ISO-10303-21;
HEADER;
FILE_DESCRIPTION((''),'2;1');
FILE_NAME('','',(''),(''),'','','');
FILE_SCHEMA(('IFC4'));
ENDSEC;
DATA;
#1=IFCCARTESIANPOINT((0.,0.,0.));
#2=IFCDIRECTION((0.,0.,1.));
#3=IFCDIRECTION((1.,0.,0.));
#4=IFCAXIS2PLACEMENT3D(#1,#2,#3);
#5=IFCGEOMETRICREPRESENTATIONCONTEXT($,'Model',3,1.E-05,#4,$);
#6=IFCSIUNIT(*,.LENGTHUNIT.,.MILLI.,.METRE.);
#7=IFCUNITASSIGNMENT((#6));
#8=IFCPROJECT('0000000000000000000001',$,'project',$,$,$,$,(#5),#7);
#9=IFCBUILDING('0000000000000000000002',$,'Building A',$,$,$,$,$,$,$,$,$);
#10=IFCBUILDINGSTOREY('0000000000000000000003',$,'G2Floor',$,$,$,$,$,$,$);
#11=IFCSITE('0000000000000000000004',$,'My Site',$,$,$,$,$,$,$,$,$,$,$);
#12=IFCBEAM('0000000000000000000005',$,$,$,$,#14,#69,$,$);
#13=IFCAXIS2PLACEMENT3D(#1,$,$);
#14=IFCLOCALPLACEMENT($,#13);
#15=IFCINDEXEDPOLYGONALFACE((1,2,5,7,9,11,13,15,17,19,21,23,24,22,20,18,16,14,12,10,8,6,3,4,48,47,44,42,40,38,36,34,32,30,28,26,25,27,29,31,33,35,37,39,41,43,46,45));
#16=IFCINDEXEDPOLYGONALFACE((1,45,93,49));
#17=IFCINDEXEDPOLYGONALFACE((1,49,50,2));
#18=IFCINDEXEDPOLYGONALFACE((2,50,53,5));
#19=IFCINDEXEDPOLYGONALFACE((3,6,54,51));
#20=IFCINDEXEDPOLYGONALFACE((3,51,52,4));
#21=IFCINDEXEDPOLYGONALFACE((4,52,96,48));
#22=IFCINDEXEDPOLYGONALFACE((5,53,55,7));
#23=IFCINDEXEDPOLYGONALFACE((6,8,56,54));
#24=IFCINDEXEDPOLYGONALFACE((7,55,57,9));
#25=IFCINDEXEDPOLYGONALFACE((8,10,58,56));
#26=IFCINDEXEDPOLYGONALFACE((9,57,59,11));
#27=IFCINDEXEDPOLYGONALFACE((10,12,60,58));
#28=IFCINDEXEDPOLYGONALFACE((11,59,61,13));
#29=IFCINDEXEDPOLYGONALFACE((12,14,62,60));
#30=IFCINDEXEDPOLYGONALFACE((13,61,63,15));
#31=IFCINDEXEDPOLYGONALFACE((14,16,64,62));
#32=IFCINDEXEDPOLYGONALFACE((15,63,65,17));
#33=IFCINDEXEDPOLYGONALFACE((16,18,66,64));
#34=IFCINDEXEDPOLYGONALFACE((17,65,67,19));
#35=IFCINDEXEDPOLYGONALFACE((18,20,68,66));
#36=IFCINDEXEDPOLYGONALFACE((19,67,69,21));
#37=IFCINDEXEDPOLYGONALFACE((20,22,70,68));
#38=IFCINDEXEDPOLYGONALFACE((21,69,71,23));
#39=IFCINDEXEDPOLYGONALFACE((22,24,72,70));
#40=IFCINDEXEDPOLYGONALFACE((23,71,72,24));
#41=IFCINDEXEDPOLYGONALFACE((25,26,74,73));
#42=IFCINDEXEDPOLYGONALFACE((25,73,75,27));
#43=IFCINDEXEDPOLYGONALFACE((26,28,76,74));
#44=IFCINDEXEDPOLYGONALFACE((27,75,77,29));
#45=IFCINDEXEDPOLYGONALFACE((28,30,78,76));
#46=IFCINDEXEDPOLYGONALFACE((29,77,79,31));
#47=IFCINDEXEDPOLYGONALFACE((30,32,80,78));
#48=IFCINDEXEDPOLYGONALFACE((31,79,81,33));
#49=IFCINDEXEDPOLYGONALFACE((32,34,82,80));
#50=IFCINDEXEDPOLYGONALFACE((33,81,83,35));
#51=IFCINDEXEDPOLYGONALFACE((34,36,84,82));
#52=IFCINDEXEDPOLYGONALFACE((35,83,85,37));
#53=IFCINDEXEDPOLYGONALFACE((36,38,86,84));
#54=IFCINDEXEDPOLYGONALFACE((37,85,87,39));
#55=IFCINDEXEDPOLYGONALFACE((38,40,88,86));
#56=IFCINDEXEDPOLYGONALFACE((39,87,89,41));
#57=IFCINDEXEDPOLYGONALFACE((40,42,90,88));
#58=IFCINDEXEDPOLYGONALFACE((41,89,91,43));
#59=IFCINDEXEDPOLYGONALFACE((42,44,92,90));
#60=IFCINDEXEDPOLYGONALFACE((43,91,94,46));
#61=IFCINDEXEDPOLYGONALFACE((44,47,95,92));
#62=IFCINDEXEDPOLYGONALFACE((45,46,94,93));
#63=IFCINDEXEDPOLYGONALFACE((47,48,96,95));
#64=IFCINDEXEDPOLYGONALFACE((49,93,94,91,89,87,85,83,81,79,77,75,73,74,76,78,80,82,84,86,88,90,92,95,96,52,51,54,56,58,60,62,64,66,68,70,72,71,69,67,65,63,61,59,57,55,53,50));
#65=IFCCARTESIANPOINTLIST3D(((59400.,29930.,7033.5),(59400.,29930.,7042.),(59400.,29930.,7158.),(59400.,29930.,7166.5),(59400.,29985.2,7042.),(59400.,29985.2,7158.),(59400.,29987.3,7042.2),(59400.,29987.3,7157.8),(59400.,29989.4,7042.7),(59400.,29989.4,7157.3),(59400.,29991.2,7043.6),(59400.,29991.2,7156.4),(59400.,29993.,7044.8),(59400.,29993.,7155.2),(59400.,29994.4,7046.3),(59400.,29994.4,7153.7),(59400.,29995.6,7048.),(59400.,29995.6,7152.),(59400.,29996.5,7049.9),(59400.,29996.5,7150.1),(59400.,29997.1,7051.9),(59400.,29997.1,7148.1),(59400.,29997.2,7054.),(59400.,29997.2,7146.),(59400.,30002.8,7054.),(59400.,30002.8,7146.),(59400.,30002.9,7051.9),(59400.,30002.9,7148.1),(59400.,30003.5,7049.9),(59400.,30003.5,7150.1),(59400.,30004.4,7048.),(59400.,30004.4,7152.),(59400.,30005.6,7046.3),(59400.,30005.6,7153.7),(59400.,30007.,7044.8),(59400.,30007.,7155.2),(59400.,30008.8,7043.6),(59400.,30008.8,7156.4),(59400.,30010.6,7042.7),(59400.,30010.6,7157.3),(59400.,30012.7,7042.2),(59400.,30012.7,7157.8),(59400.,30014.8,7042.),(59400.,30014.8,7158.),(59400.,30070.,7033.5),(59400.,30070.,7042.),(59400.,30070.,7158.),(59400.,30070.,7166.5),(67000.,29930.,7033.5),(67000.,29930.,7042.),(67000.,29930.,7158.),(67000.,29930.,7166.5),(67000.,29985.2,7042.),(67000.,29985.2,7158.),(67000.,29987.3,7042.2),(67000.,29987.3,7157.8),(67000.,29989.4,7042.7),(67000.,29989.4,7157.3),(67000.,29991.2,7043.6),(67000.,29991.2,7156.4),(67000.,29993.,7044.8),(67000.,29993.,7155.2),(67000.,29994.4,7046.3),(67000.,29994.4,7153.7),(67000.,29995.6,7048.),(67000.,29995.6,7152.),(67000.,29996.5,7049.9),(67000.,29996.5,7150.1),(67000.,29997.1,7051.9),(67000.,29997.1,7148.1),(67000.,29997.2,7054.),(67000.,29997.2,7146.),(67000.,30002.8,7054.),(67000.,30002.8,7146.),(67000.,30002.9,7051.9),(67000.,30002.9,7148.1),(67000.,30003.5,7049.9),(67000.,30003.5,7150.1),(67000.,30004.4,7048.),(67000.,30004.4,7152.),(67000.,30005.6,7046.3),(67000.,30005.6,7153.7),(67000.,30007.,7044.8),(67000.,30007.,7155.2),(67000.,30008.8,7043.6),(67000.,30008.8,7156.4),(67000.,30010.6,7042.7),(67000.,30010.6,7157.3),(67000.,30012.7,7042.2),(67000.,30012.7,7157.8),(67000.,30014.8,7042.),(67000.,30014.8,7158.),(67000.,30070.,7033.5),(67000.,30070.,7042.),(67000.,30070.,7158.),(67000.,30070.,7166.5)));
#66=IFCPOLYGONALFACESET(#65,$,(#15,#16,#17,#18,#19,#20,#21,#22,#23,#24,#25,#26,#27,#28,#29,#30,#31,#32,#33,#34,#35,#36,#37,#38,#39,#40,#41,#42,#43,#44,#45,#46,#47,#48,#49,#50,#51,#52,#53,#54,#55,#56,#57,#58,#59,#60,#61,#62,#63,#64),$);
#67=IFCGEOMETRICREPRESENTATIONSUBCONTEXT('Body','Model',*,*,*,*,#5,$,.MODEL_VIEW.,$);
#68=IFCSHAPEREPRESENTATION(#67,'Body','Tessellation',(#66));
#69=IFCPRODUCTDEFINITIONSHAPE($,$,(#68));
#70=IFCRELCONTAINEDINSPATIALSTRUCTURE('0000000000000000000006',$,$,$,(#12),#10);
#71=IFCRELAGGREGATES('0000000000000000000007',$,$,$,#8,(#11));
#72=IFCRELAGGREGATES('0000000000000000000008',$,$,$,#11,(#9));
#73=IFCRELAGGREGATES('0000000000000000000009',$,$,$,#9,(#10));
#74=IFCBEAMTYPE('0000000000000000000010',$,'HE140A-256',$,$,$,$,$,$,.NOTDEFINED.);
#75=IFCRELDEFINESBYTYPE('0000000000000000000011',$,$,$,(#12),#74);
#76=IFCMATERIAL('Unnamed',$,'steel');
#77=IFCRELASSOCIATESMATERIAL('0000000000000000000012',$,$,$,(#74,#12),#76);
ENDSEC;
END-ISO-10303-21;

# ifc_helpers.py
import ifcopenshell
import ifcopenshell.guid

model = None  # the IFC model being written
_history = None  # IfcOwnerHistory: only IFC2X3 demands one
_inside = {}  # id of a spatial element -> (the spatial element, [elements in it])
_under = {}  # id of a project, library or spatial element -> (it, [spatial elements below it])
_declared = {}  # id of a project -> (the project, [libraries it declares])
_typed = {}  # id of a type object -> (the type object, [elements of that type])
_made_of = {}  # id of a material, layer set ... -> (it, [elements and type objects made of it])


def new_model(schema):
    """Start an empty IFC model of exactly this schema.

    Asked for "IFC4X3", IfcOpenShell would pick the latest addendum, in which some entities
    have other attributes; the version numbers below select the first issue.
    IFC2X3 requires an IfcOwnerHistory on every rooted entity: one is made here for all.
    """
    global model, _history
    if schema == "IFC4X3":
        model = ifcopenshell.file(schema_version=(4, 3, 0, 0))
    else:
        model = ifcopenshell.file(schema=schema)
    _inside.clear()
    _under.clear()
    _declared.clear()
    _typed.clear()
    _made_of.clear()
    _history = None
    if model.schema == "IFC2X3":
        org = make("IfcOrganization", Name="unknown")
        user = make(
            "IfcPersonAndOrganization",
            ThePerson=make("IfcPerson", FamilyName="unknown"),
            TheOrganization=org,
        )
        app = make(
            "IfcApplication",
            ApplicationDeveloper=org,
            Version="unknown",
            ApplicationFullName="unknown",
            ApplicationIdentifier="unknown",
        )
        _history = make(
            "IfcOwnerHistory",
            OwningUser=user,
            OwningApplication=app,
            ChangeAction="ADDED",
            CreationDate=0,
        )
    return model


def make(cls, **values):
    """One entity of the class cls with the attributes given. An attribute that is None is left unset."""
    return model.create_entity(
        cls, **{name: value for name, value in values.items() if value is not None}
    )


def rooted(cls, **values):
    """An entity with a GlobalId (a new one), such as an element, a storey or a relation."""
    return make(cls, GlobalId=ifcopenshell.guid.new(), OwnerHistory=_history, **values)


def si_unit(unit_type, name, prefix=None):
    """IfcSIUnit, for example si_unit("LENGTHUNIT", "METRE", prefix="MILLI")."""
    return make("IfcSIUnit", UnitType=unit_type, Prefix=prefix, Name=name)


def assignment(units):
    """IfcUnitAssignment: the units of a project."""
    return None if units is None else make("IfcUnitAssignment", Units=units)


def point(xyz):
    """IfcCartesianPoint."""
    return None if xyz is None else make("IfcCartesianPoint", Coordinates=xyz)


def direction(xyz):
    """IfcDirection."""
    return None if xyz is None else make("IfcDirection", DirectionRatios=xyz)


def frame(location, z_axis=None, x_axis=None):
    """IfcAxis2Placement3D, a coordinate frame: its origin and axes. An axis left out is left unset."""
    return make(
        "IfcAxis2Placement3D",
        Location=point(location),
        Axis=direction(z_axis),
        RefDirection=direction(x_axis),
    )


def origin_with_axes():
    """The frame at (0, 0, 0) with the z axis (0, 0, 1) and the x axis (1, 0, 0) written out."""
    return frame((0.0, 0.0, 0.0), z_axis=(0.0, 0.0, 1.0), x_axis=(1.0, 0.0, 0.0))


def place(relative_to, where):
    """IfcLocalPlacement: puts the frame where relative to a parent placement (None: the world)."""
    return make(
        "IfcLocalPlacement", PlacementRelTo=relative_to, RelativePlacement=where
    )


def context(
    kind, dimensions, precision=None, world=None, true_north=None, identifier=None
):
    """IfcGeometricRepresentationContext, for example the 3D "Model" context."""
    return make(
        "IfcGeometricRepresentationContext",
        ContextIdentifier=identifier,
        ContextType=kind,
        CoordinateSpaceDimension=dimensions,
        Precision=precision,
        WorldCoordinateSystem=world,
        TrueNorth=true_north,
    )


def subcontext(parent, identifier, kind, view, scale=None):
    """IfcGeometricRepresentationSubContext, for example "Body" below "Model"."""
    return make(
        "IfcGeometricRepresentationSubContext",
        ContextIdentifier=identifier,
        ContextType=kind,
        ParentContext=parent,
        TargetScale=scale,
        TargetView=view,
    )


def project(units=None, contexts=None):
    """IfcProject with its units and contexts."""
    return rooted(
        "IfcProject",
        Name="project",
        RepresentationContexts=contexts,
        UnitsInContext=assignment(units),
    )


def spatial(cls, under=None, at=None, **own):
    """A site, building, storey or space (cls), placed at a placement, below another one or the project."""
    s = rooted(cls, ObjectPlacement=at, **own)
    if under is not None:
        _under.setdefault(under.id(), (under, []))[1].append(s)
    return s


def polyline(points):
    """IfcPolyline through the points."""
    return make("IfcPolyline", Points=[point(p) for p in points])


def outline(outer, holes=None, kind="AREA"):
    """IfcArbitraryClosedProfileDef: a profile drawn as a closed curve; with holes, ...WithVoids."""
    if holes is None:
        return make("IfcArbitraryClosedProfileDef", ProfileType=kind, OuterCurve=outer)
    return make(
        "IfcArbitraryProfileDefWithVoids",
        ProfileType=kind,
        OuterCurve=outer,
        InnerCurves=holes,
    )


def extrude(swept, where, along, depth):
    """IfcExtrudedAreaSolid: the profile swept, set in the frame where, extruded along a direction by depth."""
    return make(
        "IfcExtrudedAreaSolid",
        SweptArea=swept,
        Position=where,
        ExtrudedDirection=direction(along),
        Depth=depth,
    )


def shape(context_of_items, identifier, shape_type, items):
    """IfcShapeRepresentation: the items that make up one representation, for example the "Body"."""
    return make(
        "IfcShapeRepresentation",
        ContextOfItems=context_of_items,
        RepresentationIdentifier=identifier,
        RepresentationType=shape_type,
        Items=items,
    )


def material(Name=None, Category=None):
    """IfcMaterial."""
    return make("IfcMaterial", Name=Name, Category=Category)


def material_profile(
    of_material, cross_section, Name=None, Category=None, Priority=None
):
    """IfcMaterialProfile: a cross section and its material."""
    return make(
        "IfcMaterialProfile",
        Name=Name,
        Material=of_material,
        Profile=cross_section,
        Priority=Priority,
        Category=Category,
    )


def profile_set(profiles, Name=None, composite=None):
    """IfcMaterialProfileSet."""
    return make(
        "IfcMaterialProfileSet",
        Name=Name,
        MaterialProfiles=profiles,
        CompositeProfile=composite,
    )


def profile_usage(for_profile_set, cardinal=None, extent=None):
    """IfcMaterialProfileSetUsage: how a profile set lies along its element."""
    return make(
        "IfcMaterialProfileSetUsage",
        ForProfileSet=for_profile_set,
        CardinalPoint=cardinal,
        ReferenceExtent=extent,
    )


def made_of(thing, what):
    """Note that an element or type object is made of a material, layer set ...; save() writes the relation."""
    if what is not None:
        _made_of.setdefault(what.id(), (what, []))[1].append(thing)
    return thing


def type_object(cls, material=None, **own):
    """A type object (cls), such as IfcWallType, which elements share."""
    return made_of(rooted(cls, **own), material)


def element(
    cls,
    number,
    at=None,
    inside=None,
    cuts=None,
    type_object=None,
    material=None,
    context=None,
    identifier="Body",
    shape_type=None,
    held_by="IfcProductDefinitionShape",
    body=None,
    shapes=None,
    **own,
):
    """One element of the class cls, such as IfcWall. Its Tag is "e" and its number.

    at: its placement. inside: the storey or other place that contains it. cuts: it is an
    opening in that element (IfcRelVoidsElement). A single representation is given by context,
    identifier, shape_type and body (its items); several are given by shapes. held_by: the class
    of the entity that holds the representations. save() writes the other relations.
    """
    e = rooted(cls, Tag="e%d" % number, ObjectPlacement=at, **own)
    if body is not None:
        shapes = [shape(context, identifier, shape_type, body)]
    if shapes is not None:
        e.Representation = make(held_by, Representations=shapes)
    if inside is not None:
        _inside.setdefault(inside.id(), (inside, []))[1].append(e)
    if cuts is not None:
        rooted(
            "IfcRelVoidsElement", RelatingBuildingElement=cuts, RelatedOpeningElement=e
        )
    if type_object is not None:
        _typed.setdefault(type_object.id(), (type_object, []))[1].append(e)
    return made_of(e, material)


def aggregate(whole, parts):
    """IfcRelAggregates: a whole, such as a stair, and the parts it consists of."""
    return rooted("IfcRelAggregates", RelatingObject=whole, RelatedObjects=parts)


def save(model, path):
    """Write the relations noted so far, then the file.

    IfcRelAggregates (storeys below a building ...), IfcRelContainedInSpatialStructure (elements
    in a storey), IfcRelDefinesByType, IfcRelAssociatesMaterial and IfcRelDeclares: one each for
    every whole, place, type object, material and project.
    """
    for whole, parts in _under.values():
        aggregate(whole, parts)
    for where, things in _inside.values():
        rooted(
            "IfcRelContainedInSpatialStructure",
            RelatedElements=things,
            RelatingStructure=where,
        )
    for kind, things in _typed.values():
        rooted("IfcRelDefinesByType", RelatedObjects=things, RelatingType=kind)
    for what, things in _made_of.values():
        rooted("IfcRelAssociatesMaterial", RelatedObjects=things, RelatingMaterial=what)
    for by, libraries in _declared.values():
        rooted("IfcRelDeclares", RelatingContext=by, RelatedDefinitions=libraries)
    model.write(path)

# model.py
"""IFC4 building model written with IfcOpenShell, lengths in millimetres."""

from ifc_helpers import new_model, si_unit, frame, origin_with_axes, place, context, subcontext, project, spatial, polyline, outline, extrude, material, material_profile, profile_set, profile_usage, type_object, element, save


model = new_model("IFC4")

# Units and contexts
model_context = context("Model", 3, precision=1e-05, world=origin_with_axes())
body_context = subcontext(model_context, "Body", "Model", "MODEL_VIEW")
ifc_project = project(units=[si_unit("LENGTHUNIT", "METRE", prefix="MILLI")], contexts=[model_context])

# Site, building, storey
site = spatial("IfcSite", under=ifc_project, Name="My Site")
building = spatial("IfcBuilding", under=site, Name="Building A")
storey = spatial("IfcBuildingStorey", under=building, Name="G2Floor")

# Beam
ifc_material_1 = material(Name="Unnamed", Category="steel")
ifc_material_profile_1 = material_profile(ifc_material_1, outline(polyline([(70.0, -66.5), (70.0, -58.0), (70.0, -58.0), (14.8, -58.0), (14.8, -58.0), (12.7, -57.8), (12.7, -57.8), (10.6, -57.3), (10.6, -57.3), (8.8, -56.4), (8.8, -56.4), (7.0, -55.2), (7.0, -55.2), (5.6, -53.7), (5.6, -53.7), (4.4, -52.0), (4.4, -52.0), (3.5, -50.1), (3.5, -50.1), (2.9, -48.1), (2.9, -48.1), (2.8, -46.0), (2.8, -46.0), (2.8, 46.0), (2.8, 46.0), (2.9, 48.1), (2.9, 48.1), (3.5, 50.1), (3.5, 50.1), (4.4, 52.0), (4.4, 52.0), (5.6, 53.7), (5.6, 53.7), (7.0, 55.2), (7.0, 55.2), (8.8, 56.4), (8.8, 56.4), (10.6, 57.3), (10.6, 57.3), (12.7, 57.8), (12.7, 57.8), (14.8, 58.0), (14.8, 58.0), (70.0, 58.0), (70.0, 58.0), (70.0, 66.5), (70.0, 66.5), (-70.0, 66.5), (-70.0, 66.5), (-70.0, 58.0), (-70.0, 58.0), (-14.8, 58.0), (-14.8, 58.0), (-12.7, 57.8), (-12.7, 57.8), (-10.6, 57.3), (-10.6, 57.3), (-8.8, 56.4), (-8.8, 56.4), (-7.0, 55.2), (-7.0, 55.2), (-5.6, 53.7), (-5.6, 53.7), (-4.4, 52.0), (-4.4, 52.0), (-3.5, 50.1), (-3.5, 50.1), (-2.9, 48.1), (-2.9, 48.1), (-2.8, 46.0), (-2.8, 46.0), (-2.8, -46.0), (-2.8, -46.0), (-2.9, -48.1), (-2.9, -48.1), (-3.5, -50.1), (-3.5, -50.1), (-4.4, -52.0), (-4.4, -52.0), (-5.6, -53.7), (-5.6, -53.7), (-7.0, -55.2), (-7.0, -55.2), (-8.8, -56.4), (-8.8, -56.4), (-10.6, -57.3), (-10.6, -57.3), (-12.7, -57.8), (-12.7, -57.8), (-14.8, -58.0), (-14.8, -58.0), (-70.0, -58.0), (-70.0, -58.0), (-70.0, -66.5), (-70.0, -66.5), (70.0, -66.5)])))
ifc_profile_set_1 = profile_set([ifc_material_profile_1], Name="HE140A-256")
ifc_profile_usage_1 = profile_usage(ifc_profile_set_1)
beam_type_1 = type_object("IfcBeamType", Name="HE140A-256", PredefinedType="NOTDEFINED", material=ifc_profile_set_1)
beam_1_placement = place(None, frame((59400.0, 30000.0, 7100.0), z_axis=(1.0, 0.0, 0.0), x_axis=(0.0, -1.0, 0.0)))
element("IfcBeam", 1, at=beam_1_placement, inside=storey, type_object=beam_type_1, material=ifc_profile_usage_1, context=body_context, shape_type="SweptSolid", body=[
    extrude(outline(polyline([(70.0, -66.5), (70.0, -58.0), (70.0, -58.0), (14.8, -58.0), (14.8, -58.0), (12.7, -57.8), (12.7, -57.8), (10.6, -57.3), (10.6, -57.3), (8.8, -56.4), (8.8, -56.4), (7.0, -55.2), (7.0, -55.2), (5.6, -53.7), (5.6, -53.7), (4.4, -52.0), (4.4, -52.0), (3.5, -50.1), (3.5, -50.1), (2.9, -48.1), (2.9, -48.1), (2.8, -46.0), (2.8, -46.0), (2.8, 46.0), (2.8, 46.0), (2.9, 48.1), (2.9, 48.1), (3.5, 50.1), (3.5, 50.1), (4.4, 52.0), (4.4, 52.0), (5.6, 53.7), (5.6, 53.7), (7.0, 55.2), (7.0, 55.2), (8.8, 56.4), (8.8, 56.4), (10.6, 57.3), (10.6, 57.3), (12.7, 57.8), (12.7, 57.8), (14.8, 58.0), (14.8, 58.0), (70.0, 58.0), (70.0, 58.0), (70.0, 66.5), (70.0, 66.5), (-70.0, 66.5), (-70.0, 66.5), (-70.0, 58.0), (-70.0, 58.0), (-14.8, 58.0), (-14.8, 58.0), (-12.7, 57.8), (-12.7, 57.8), (-10.6, 57.3), (-10.6, 57.3), (-8.8, 56.4), (-8.8, 56.4), (-7.0, 55.2), (-7.0, 55.2), (-5.6, 53.7), (-5.6, 53.7), (-4.4, 52.0), (-4.4, 52.0), (-3.5, 50.1), (-3.5, 50.1), (-2.9, 48.1), (-2.9, 48.1), (-2.8, 46.0), (-2.8, 46.0), (-2.8, -46.0), (-2.8, -46.0), (-2.9, -48.1), (-2.9, -48.1), (-3.5, -50.1), (-3.5, -50.1), (-4.4, -52.0), (-4.4, -52.0), (-5.6, -53.7), (-5.6, -53.7), (-7.0, -55.2), (-7.0, -55.2), (-8.8, -56.4), (-8.8, -56.4), (-10.6, -57.3), (-10.6, -57.3), (-12.7, -57.8), (-12.7, -57.8), (-14.8, -58.0), (-14.8, -58.0), (-70.0, -58.0), (-70.0, -58.0), (-70.0, -66.5), (-70.0, -66.5), (70.0, -66.5)])), origin_with_axes(), (0.0, 0.0, 1.0), 7600.0),
])

save(model, "model.ifc")
